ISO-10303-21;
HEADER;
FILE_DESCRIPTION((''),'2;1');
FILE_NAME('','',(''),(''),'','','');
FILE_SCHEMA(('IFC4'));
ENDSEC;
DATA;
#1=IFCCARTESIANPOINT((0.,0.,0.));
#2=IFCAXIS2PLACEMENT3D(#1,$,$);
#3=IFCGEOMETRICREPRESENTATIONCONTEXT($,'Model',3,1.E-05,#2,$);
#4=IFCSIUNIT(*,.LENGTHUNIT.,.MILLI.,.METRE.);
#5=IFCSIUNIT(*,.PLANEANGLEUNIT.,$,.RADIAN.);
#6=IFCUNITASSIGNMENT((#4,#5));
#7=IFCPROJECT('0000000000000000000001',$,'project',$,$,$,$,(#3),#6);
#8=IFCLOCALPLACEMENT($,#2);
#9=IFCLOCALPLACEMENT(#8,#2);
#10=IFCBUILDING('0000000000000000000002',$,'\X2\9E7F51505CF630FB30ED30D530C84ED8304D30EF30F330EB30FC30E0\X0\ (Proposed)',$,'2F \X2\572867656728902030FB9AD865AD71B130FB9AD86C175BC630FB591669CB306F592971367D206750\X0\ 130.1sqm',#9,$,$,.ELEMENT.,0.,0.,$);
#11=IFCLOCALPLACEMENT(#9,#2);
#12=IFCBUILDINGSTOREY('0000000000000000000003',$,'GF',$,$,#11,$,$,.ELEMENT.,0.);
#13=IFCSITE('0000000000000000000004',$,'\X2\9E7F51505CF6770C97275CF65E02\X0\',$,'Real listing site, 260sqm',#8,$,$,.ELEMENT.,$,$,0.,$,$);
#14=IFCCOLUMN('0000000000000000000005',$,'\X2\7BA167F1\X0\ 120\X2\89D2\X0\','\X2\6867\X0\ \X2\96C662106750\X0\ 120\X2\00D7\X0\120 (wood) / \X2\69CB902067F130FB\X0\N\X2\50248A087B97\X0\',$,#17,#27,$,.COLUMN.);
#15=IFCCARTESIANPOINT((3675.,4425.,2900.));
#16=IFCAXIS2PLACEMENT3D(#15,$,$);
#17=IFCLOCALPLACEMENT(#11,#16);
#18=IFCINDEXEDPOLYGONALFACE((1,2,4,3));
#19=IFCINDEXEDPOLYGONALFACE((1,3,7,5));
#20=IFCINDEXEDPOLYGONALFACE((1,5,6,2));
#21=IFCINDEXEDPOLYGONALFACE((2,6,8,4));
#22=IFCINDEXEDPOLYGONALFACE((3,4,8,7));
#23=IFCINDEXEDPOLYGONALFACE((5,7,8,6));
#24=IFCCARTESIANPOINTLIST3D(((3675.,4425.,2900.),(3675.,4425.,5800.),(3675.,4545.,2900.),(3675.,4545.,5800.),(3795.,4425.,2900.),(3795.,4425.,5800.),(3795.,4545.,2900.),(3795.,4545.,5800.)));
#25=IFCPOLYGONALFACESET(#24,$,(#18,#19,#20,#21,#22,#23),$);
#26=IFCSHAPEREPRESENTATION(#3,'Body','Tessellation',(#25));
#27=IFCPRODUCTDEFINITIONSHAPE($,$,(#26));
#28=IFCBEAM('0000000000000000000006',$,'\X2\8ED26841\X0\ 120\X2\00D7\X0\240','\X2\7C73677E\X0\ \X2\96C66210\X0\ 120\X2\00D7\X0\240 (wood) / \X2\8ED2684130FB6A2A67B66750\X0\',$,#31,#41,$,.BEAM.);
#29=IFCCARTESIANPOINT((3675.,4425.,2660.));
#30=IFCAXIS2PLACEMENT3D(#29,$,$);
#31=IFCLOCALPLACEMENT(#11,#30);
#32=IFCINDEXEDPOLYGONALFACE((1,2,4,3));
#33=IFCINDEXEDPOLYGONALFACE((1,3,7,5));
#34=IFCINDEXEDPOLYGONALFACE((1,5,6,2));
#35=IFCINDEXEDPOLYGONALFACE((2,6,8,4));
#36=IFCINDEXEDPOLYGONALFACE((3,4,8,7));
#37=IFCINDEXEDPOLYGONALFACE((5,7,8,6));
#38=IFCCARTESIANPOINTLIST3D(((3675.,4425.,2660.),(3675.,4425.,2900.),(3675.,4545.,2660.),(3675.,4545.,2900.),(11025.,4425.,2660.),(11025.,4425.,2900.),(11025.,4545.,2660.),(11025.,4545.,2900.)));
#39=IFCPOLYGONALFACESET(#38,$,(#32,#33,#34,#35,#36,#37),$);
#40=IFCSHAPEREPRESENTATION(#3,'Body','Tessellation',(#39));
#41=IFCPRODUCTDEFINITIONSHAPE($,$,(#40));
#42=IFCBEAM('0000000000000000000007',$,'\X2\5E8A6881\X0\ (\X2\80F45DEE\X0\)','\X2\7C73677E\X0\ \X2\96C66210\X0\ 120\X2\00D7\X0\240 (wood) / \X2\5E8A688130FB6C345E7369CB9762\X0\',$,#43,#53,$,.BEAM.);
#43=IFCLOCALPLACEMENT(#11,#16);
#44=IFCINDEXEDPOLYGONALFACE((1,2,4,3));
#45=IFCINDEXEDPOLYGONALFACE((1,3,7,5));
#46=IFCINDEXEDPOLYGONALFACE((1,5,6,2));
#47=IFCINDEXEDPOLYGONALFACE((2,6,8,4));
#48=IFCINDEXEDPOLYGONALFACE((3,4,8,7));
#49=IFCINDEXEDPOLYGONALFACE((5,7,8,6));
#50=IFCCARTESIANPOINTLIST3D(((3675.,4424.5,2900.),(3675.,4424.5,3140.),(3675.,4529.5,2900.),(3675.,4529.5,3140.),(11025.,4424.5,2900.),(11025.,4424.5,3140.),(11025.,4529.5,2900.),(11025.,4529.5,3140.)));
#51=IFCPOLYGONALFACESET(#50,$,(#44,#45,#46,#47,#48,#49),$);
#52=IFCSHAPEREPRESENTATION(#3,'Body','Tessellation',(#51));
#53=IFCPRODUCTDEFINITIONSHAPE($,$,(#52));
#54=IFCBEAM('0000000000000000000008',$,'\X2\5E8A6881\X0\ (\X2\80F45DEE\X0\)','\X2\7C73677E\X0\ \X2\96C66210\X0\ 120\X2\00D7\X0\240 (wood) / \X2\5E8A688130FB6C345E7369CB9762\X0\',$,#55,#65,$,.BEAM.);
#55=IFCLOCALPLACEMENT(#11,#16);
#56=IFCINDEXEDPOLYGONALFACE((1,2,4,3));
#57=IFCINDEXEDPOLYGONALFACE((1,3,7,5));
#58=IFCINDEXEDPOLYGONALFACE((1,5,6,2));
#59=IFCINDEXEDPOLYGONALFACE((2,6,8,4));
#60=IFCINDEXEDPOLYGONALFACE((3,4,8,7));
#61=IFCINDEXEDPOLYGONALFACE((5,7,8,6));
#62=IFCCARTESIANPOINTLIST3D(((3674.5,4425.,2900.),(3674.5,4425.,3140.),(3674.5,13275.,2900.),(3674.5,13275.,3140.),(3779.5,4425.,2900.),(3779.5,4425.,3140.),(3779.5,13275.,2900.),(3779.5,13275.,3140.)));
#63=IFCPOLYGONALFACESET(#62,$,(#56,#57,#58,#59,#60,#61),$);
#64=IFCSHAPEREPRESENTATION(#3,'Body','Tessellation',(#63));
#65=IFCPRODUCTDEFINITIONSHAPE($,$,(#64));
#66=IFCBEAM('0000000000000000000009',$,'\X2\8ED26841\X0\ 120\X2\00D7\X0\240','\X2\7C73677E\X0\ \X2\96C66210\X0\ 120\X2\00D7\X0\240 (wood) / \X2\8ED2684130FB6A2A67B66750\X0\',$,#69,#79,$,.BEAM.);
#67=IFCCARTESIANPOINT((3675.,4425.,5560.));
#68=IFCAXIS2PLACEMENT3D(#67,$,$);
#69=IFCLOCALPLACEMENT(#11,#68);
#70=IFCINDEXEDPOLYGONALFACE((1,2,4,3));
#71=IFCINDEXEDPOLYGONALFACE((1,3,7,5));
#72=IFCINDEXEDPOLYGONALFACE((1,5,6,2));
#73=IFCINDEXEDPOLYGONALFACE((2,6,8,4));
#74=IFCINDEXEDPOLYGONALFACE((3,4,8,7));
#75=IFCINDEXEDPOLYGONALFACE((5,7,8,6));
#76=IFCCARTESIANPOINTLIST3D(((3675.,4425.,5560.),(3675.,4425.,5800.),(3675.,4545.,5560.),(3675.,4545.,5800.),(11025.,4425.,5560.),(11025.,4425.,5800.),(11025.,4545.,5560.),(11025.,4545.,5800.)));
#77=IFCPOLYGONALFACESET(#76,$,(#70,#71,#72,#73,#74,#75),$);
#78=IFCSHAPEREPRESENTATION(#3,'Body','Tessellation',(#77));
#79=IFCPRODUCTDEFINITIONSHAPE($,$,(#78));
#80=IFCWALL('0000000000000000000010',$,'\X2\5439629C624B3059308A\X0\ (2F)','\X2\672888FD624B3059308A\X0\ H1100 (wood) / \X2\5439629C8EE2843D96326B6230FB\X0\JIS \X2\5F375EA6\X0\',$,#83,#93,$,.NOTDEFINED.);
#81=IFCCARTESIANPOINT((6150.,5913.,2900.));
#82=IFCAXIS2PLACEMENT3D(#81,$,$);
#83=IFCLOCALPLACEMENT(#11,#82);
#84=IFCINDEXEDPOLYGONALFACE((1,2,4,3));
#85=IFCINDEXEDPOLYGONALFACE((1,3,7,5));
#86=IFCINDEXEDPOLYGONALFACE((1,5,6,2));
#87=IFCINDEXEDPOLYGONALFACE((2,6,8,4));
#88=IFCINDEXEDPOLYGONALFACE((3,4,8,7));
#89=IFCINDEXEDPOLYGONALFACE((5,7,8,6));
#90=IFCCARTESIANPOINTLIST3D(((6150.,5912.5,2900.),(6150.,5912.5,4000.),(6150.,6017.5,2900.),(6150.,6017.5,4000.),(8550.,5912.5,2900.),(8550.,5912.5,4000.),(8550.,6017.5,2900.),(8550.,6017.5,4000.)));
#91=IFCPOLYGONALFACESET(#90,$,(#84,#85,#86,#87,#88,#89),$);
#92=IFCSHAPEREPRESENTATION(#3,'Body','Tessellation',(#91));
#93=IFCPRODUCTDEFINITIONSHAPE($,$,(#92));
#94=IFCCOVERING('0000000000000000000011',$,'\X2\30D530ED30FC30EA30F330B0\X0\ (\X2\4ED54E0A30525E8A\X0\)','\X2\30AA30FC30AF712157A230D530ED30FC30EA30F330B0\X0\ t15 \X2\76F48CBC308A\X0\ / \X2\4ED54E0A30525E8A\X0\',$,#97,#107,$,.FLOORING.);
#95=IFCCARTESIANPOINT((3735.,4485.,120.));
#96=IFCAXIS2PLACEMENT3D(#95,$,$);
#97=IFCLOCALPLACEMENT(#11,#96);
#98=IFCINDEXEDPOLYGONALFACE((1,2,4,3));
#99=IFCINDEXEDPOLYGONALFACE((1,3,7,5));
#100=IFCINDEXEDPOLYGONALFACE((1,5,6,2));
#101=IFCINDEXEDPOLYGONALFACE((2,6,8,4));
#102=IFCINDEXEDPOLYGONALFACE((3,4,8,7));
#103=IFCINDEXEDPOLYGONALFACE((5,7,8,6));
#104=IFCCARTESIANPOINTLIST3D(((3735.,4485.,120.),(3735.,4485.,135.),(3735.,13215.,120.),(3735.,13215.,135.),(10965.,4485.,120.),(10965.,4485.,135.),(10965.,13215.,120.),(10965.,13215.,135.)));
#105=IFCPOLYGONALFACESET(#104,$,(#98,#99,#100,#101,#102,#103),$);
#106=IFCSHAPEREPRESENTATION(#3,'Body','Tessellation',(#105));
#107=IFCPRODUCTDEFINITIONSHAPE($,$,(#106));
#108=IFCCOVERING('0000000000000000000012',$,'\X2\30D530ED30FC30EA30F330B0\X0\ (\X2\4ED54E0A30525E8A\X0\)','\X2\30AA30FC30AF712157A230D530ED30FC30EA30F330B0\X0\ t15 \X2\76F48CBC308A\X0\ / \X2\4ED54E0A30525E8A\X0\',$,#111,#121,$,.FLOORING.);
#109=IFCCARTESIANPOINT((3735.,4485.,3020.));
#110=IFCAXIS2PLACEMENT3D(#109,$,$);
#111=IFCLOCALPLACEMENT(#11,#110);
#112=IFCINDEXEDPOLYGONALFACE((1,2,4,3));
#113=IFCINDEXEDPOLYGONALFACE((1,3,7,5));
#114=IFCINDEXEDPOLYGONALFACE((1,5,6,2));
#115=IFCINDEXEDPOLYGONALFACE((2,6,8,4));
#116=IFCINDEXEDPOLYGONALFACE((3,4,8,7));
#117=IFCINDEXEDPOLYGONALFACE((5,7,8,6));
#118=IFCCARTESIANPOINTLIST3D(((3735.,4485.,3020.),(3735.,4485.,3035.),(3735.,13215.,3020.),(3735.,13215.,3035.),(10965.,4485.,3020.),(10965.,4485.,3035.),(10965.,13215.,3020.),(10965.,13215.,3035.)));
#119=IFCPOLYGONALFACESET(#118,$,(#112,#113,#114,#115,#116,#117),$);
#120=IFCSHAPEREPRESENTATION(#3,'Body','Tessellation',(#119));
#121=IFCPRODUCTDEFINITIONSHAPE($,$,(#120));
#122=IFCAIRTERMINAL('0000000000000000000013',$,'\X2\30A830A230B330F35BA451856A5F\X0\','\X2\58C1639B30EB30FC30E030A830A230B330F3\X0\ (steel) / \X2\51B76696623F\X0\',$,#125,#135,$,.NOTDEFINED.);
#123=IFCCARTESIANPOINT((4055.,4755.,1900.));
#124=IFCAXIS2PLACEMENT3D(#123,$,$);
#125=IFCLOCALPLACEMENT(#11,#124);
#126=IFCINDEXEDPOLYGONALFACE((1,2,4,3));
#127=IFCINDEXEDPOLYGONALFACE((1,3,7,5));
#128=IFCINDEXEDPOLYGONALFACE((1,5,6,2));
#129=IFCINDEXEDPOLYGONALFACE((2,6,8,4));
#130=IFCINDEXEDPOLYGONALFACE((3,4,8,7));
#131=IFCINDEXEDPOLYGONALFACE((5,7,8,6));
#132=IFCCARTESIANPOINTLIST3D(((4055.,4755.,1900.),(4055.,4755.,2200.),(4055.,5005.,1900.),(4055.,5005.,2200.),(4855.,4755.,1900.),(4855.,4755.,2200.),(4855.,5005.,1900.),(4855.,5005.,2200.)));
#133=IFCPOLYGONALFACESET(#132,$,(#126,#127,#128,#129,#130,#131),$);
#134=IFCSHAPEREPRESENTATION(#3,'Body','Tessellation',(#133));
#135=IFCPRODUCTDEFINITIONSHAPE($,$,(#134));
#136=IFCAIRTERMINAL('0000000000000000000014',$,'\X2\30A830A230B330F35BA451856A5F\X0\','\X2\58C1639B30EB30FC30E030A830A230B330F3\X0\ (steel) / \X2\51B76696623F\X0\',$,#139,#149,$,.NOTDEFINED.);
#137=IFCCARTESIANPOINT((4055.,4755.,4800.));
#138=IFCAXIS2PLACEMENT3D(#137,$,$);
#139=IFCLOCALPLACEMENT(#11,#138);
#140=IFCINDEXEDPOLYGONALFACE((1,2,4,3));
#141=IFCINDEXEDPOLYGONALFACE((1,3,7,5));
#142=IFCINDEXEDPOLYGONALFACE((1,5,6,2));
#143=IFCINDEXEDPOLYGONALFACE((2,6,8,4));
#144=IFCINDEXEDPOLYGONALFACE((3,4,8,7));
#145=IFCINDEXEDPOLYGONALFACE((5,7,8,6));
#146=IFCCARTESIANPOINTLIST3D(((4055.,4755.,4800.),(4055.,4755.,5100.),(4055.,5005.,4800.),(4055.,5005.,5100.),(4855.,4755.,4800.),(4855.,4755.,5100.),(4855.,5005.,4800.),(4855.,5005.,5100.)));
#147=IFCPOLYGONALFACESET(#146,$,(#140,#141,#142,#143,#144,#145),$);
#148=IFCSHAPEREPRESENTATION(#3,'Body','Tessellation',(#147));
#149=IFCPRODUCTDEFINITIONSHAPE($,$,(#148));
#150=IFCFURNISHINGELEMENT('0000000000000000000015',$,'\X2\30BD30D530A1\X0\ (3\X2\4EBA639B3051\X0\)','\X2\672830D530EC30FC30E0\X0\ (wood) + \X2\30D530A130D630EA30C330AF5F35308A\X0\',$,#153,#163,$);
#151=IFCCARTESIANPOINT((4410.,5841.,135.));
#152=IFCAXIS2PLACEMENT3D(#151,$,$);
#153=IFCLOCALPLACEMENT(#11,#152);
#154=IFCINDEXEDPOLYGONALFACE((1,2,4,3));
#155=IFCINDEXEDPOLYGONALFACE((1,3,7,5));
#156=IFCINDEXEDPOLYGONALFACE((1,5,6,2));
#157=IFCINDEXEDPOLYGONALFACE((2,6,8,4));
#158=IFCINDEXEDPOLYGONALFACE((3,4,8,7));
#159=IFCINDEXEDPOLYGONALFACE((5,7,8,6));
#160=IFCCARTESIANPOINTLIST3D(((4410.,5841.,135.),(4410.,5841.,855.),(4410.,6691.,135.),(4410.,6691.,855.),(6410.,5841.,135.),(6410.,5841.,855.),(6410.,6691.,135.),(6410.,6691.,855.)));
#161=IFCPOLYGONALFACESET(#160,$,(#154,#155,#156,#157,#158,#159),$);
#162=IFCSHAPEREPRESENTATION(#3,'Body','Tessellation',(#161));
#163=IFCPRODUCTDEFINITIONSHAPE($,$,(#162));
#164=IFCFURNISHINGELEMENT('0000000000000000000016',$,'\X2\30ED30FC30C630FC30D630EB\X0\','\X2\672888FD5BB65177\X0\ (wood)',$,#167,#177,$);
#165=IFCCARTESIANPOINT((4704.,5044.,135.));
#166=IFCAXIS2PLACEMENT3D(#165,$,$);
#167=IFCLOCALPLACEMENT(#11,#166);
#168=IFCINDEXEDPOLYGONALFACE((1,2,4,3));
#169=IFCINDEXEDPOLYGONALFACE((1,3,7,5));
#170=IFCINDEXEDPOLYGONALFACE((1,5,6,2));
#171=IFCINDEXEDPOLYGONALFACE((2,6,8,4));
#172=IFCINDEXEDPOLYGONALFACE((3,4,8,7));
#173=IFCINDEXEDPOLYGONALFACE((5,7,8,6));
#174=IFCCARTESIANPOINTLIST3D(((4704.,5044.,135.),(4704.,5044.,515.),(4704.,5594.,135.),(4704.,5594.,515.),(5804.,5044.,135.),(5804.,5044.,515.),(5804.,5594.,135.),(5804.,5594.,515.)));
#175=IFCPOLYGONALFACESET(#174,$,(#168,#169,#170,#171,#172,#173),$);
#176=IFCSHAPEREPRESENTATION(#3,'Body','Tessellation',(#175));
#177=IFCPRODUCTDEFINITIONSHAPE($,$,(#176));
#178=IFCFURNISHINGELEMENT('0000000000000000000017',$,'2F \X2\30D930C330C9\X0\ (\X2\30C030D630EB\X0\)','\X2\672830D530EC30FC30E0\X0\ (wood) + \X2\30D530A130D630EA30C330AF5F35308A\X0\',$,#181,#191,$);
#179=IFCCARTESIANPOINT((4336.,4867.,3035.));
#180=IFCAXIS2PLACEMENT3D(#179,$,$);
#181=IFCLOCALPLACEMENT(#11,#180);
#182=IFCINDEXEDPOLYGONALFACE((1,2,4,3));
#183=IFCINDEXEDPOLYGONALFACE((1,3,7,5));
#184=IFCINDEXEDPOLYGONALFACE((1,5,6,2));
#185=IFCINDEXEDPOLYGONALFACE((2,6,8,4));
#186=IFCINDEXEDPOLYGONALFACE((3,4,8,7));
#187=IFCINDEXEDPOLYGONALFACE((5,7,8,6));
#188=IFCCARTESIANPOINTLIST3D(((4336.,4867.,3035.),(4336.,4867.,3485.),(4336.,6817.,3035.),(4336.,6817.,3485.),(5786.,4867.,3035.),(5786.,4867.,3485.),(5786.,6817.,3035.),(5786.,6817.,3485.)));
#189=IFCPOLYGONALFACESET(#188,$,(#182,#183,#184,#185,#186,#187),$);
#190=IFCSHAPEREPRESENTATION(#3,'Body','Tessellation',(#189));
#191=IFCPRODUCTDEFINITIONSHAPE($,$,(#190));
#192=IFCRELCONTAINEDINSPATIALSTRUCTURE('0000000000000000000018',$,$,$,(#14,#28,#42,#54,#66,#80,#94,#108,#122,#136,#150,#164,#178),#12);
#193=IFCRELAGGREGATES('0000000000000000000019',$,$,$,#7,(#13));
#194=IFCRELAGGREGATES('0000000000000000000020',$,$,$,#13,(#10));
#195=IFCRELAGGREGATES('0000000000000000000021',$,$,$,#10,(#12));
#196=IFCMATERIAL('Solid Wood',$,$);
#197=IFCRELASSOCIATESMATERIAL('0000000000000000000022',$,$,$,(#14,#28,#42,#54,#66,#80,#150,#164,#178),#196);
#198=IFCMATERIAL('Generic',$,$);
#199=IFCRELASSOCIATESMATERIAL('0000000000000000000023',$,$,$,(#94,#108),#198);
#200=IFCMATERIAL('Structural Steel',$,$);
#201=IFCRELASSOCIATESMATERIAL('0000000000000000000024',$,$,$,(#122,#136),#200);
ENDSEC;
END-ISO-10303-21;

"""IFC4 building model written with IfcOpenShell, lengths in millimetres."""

from ifc_helpers import new_model, si_unit, frame, frame_2d, origin, place, context, project, spatial, rectangle, extrude, material, element, save


model = new_model("IFC4")

# Units and contexts
model_context = context("Model", 3, precision=1e-05, world=origin())
ifc_project = project(units=[si_unit("LENGTHUNIT", "METRE", prefix="MILLI"), si_unit("PLANEANGLEUNIT", "RADIAN")], contexts=[model_context])

# Site, building, storey
site_placement = place(None, origin())
site = spatial("IfcSite", under=ifc_project, at=site_placement, Name="鹿児島県霧島市", ObjectType="Real listing site, 260sqm", CompositionType="ELEMENT", RefElevation=0.0)
building_placement = place(site_placement, origin())
building = spatial("IfcBuilding", under=site, at=building_placement, Name="鹿児島・ロフト付きワンルーム (Proposed)", ObjectType="2F 在来木造・高断熱・高気密・外構は天然素材 130.1sqm", CompositionType="ELEMENT", ElevationOfRefHeight=0.0, ElevationOfTerrain=0.0)
storey_placement = place(building_placement, origin())
storey = spatial("IfcBuildingStorey", under=building, at=storey_placement, Name="GF", CompositionType="ELEMENT", Elevation=0.0)

# Column
ifc_material_1 = material(Name="Solid Wood")
column_placement = place(storey_placement, frame((3675.0, 4425.0, 2900.0)))
element("IfcColumn", 1, at=column_placement, inside=storey, material=ifc_material_1, Name="管柱 120角", Description="桧 集成材 120×120 (wood) / 構造柱・N値計算", PredefinedType="COLUMN", context=model_context, shape_type="SweptSolid", body=[
    extrude(rectangle(XDim=120.0, YDim=120.0, at=frame_2d((60.0, 60.0))), frame((3675.0, 4425.0, 2900.0)), (0.0, 0.0, 1.0), 2900.0),
])

# Beams
beam_1_placement = place(storey_placement, frame((3675.0, 4425.0, 2660.0)))
element("IfcBeam", 2, at=beam_1_placement, inside=storey, material=ifc_material_1, Name="軒桁 120×240", Description="米松 集成 120×240 (wood) / 軒桁・横架材", PredefinedType="BEAM", context=model_context, shape_type="SweptSolid", body=[
    extrude(rectangle(XDim=7350.0, YDim=120.0, at=frame_2d((3675.0, 60.0))), frame((3675.0, 4425.0, 2660.0)), (0.0, 0.0, 1.0), 240.0),
])
beam_2_placement = place(storey_placement, frame((3675.0, 4425.0, 2900.0)))
element("IfcBeam", 3, at=beam_2_placement, inside=storey, material=ifc_material_1, Name="床梁 (胴差)", Description="米松 集成 120×240 (wood) / 床梁・水平構面", PredefinedType="BEAM", context=model_context, shape_type="SweptSolid", body=[
    extrude(rectangle(XDim=7350.0, YDim=105.0, at=frame_2d((3675.0, 52.0))), frame((3675.0, 4425.0, 2900.0)), (0.0, 0.0, 1.0), 240.0),
])
beam_3_placement = place(storey_placement, frame((3675.0, 4425.0, 2900.0)))
element("IfcBeam", 4, at=beam_3_placement, inside=storey, material=ifc_material_1, Name="床梁 (胴差)", Description="米松 集成 120×240 (wood) / 床梁・水平構面", PredefinedType="BEAM", context=model_context, shape_type="SweptSolid", body=[
    extrude(rectangle(XDim=105.0, YDim=8850.0, at=frame_2d((52.0, 4425.0))), frame((3675.0, 4425.0, 2900.0)), (0.0, 0.0, 1.0), 240.0),
])
beam_4_placement = place(storey_placement, frame((3675.0, 4425.0, 5560.0)))
element("IfcBeam", 5, at=beam_4_placement, inside=storey, material=ifc_material_1, Name="軒桁 120×240", Description="米松 集成 120×240 (wood) / 軒桁・横架材", PredefinedType="BEAM", context=model_context, shape_type="SweptSolid", body=[
    extrude(rectangle(XDim=7350.0, YDim=120.0, at=frame_2d((3675.0, 60.0))), frame((3675.0, 4425.0, 5560.0)), (0.0, 0.0, 1.0), 240.0),
])

# Wall
wall_placement = place(storey_placement, frame((6150.0, 5913.0, 2900.0)))
element("IfcWall", 6, at=wall_placement, inside=storey, material=ifc_material_1, Name="吹抜手すり (2F)", Description="木製手すり H1100 (wood) / 吹抜転落防止・JIS 強度", PredefinedType="NOTDEFINED", context=model_context, shape_type="SweptSolid", body=[
    extrude(rectangle(XDim=2400.0, YDim=105.0, at=frame_2d((1200.0, 52.0))), frame((6150.0, 5913.0, 2900.0)), (0.0, 0.0, 1.0), 1100.0),
])

# Coverings
ifc_material_2 = material(Name="Generic")
covering_1_placement = place(storey_placement, frame((3735.0, 4485.0, 120.0)))
element("IfcCovering", 7, at=covering_1_placement, inside=storey, material=ifc_material_2, Name="フローリング (仕上げ床)", Description="オーク無垢フローリング t15 直貼り / 仕上げ床", PredefinedType="FLOORING", context=model_context, shape_type="SweptSolid", body=[
    extrude(rectangle(XDim=7230.0, YDim=8730.0, at=frame_2d((3615.0, 4365.0))), frame((3735.0, 4485.0, 120.0)), (0.0, 0.0, 1.0), 15.0),
])
covering_2_placement = place(storey_placement, frame((3735.0, 4485.0, 3020.0)))
element("IfcCovering", 8, at=covering_2_placement, inside=storey, material=ifc_material_2, Name="フローリング (仕上げ床)", Description="オーク無垢フローリング t15 直貼り / 仕上げ床", PredefinedType="FLOORING", context=model_context, shape_type="SweptSolid", body=[
    extrude(rectangle(XDim=7230.0, YDim=8730.0, at=frame_2d((3615.0, 4365.0))), frame((3735.0, 4485.0, 3020.0)), (0.0, 0.0, 1.0), 15.0),
])

# Air terminals
ifc_material_3 = material(Name="Structural Steel")
air_terminal_1_placement = place(storey_placement, frame((4055.0, 4755.0, 1900.0)))
element("IfcAirTerminal", 9, at=air_terminal_1_placement, inside=storey, material=ifc_material_3, Name="エアコン室内機", Description="壁掛ルームエアコン (steel) / 冷暖房", PredefinedType="NOTDEFINED", context=model_context, shape_type="SweptSolid", body=[
    extrude(rectangle(XDim=800.0, YDim=250.0, at=frame_2d((400.0, 125.0))), frame((4055.0, 4755.0, 1900.0)), (0.0, 0.0, 1.0), 300.0),
])
air_terminal_2_placement = place(storey_placement, frame((4055.0, 4755.0, 4800.0)))
element("IfcAirTerminal", 10, at=air_terminal_2_placement, inside=storey, material=ifc_material_3, Name="エアコン室内機", Description="壁掛ルームエアコン (steel) / 冷暖房", PredefinedType="NOTDEFINED", context=model_context, shape_type="SweptSolid", body=[
    extrude(rectangle(XDim=800.0, YDim=250.0, at=frame_2d((400.0, 125.0))), frame((4055.0, 4755.0, 4800.0)), (0.0, 0.0, 1.0), 300.0),
])

# Furnishing elements
furnishing_1_placement = place(storey_placement, frame((4410.0, 5841.0, 135.0)))
element("IfcFurnishingElement", 11, at=furnishing_1_placement, inside=storey, material=ifc_material_1, Name="ソファ (3人掛け)", Description="木フレーム (wood) + ファブリック張り", context=model_context, shape_type="SweptSolid", body=[
    extrude(rectangle(XDim=2000.0, YDim=850.0, at=frame_2d((1000.0, 425.0))), frame((4410.0, 5841.0, 135.0)), (0.0, 0.0, 1.0), 720.0),
])
furnishing_2_placement = place(storey_placement, frame((4704.0, 5044.0, 135.0)))
element("IfcFurnishingElement", 12, at=furnishing_2_placement, inside=storey, material=ifc_material_1, Name="ローテーブル", Description="木製家具 (wood)", context=model_context, shape_type="SweptSolid", body=[
    extrude(rectangle(XDim=1100.0, YDim=550.0, at=frame_2d((550.0, 275.0))), frame((4704.0, 5044.0, 135.0)), (0.0, 0.0, 1.0), 380.0),
])
furnishing_3_placement = place(storey_placement, frame((4336.0, 4867.0, 3035.0)))
element("IfcFurnishingElement", 13, at=furnishing_3_placement, inside=storey, material=ifc_material_1, Name="2F ベッド (ダブル)", Description="木フレーム (wood) + ファブリック張り", context=model_context, shape_type="SweptSolid", body=[
    extrude(rectangle(XDim=1450.0, YDim=1950.0, at=frame_2d((725.0, 975.0))), frame((4336.0, 4867.0, 3035.0)), (0.0, 0.0, 1.0), 450.0),
])

save(model, "model.ifc")
